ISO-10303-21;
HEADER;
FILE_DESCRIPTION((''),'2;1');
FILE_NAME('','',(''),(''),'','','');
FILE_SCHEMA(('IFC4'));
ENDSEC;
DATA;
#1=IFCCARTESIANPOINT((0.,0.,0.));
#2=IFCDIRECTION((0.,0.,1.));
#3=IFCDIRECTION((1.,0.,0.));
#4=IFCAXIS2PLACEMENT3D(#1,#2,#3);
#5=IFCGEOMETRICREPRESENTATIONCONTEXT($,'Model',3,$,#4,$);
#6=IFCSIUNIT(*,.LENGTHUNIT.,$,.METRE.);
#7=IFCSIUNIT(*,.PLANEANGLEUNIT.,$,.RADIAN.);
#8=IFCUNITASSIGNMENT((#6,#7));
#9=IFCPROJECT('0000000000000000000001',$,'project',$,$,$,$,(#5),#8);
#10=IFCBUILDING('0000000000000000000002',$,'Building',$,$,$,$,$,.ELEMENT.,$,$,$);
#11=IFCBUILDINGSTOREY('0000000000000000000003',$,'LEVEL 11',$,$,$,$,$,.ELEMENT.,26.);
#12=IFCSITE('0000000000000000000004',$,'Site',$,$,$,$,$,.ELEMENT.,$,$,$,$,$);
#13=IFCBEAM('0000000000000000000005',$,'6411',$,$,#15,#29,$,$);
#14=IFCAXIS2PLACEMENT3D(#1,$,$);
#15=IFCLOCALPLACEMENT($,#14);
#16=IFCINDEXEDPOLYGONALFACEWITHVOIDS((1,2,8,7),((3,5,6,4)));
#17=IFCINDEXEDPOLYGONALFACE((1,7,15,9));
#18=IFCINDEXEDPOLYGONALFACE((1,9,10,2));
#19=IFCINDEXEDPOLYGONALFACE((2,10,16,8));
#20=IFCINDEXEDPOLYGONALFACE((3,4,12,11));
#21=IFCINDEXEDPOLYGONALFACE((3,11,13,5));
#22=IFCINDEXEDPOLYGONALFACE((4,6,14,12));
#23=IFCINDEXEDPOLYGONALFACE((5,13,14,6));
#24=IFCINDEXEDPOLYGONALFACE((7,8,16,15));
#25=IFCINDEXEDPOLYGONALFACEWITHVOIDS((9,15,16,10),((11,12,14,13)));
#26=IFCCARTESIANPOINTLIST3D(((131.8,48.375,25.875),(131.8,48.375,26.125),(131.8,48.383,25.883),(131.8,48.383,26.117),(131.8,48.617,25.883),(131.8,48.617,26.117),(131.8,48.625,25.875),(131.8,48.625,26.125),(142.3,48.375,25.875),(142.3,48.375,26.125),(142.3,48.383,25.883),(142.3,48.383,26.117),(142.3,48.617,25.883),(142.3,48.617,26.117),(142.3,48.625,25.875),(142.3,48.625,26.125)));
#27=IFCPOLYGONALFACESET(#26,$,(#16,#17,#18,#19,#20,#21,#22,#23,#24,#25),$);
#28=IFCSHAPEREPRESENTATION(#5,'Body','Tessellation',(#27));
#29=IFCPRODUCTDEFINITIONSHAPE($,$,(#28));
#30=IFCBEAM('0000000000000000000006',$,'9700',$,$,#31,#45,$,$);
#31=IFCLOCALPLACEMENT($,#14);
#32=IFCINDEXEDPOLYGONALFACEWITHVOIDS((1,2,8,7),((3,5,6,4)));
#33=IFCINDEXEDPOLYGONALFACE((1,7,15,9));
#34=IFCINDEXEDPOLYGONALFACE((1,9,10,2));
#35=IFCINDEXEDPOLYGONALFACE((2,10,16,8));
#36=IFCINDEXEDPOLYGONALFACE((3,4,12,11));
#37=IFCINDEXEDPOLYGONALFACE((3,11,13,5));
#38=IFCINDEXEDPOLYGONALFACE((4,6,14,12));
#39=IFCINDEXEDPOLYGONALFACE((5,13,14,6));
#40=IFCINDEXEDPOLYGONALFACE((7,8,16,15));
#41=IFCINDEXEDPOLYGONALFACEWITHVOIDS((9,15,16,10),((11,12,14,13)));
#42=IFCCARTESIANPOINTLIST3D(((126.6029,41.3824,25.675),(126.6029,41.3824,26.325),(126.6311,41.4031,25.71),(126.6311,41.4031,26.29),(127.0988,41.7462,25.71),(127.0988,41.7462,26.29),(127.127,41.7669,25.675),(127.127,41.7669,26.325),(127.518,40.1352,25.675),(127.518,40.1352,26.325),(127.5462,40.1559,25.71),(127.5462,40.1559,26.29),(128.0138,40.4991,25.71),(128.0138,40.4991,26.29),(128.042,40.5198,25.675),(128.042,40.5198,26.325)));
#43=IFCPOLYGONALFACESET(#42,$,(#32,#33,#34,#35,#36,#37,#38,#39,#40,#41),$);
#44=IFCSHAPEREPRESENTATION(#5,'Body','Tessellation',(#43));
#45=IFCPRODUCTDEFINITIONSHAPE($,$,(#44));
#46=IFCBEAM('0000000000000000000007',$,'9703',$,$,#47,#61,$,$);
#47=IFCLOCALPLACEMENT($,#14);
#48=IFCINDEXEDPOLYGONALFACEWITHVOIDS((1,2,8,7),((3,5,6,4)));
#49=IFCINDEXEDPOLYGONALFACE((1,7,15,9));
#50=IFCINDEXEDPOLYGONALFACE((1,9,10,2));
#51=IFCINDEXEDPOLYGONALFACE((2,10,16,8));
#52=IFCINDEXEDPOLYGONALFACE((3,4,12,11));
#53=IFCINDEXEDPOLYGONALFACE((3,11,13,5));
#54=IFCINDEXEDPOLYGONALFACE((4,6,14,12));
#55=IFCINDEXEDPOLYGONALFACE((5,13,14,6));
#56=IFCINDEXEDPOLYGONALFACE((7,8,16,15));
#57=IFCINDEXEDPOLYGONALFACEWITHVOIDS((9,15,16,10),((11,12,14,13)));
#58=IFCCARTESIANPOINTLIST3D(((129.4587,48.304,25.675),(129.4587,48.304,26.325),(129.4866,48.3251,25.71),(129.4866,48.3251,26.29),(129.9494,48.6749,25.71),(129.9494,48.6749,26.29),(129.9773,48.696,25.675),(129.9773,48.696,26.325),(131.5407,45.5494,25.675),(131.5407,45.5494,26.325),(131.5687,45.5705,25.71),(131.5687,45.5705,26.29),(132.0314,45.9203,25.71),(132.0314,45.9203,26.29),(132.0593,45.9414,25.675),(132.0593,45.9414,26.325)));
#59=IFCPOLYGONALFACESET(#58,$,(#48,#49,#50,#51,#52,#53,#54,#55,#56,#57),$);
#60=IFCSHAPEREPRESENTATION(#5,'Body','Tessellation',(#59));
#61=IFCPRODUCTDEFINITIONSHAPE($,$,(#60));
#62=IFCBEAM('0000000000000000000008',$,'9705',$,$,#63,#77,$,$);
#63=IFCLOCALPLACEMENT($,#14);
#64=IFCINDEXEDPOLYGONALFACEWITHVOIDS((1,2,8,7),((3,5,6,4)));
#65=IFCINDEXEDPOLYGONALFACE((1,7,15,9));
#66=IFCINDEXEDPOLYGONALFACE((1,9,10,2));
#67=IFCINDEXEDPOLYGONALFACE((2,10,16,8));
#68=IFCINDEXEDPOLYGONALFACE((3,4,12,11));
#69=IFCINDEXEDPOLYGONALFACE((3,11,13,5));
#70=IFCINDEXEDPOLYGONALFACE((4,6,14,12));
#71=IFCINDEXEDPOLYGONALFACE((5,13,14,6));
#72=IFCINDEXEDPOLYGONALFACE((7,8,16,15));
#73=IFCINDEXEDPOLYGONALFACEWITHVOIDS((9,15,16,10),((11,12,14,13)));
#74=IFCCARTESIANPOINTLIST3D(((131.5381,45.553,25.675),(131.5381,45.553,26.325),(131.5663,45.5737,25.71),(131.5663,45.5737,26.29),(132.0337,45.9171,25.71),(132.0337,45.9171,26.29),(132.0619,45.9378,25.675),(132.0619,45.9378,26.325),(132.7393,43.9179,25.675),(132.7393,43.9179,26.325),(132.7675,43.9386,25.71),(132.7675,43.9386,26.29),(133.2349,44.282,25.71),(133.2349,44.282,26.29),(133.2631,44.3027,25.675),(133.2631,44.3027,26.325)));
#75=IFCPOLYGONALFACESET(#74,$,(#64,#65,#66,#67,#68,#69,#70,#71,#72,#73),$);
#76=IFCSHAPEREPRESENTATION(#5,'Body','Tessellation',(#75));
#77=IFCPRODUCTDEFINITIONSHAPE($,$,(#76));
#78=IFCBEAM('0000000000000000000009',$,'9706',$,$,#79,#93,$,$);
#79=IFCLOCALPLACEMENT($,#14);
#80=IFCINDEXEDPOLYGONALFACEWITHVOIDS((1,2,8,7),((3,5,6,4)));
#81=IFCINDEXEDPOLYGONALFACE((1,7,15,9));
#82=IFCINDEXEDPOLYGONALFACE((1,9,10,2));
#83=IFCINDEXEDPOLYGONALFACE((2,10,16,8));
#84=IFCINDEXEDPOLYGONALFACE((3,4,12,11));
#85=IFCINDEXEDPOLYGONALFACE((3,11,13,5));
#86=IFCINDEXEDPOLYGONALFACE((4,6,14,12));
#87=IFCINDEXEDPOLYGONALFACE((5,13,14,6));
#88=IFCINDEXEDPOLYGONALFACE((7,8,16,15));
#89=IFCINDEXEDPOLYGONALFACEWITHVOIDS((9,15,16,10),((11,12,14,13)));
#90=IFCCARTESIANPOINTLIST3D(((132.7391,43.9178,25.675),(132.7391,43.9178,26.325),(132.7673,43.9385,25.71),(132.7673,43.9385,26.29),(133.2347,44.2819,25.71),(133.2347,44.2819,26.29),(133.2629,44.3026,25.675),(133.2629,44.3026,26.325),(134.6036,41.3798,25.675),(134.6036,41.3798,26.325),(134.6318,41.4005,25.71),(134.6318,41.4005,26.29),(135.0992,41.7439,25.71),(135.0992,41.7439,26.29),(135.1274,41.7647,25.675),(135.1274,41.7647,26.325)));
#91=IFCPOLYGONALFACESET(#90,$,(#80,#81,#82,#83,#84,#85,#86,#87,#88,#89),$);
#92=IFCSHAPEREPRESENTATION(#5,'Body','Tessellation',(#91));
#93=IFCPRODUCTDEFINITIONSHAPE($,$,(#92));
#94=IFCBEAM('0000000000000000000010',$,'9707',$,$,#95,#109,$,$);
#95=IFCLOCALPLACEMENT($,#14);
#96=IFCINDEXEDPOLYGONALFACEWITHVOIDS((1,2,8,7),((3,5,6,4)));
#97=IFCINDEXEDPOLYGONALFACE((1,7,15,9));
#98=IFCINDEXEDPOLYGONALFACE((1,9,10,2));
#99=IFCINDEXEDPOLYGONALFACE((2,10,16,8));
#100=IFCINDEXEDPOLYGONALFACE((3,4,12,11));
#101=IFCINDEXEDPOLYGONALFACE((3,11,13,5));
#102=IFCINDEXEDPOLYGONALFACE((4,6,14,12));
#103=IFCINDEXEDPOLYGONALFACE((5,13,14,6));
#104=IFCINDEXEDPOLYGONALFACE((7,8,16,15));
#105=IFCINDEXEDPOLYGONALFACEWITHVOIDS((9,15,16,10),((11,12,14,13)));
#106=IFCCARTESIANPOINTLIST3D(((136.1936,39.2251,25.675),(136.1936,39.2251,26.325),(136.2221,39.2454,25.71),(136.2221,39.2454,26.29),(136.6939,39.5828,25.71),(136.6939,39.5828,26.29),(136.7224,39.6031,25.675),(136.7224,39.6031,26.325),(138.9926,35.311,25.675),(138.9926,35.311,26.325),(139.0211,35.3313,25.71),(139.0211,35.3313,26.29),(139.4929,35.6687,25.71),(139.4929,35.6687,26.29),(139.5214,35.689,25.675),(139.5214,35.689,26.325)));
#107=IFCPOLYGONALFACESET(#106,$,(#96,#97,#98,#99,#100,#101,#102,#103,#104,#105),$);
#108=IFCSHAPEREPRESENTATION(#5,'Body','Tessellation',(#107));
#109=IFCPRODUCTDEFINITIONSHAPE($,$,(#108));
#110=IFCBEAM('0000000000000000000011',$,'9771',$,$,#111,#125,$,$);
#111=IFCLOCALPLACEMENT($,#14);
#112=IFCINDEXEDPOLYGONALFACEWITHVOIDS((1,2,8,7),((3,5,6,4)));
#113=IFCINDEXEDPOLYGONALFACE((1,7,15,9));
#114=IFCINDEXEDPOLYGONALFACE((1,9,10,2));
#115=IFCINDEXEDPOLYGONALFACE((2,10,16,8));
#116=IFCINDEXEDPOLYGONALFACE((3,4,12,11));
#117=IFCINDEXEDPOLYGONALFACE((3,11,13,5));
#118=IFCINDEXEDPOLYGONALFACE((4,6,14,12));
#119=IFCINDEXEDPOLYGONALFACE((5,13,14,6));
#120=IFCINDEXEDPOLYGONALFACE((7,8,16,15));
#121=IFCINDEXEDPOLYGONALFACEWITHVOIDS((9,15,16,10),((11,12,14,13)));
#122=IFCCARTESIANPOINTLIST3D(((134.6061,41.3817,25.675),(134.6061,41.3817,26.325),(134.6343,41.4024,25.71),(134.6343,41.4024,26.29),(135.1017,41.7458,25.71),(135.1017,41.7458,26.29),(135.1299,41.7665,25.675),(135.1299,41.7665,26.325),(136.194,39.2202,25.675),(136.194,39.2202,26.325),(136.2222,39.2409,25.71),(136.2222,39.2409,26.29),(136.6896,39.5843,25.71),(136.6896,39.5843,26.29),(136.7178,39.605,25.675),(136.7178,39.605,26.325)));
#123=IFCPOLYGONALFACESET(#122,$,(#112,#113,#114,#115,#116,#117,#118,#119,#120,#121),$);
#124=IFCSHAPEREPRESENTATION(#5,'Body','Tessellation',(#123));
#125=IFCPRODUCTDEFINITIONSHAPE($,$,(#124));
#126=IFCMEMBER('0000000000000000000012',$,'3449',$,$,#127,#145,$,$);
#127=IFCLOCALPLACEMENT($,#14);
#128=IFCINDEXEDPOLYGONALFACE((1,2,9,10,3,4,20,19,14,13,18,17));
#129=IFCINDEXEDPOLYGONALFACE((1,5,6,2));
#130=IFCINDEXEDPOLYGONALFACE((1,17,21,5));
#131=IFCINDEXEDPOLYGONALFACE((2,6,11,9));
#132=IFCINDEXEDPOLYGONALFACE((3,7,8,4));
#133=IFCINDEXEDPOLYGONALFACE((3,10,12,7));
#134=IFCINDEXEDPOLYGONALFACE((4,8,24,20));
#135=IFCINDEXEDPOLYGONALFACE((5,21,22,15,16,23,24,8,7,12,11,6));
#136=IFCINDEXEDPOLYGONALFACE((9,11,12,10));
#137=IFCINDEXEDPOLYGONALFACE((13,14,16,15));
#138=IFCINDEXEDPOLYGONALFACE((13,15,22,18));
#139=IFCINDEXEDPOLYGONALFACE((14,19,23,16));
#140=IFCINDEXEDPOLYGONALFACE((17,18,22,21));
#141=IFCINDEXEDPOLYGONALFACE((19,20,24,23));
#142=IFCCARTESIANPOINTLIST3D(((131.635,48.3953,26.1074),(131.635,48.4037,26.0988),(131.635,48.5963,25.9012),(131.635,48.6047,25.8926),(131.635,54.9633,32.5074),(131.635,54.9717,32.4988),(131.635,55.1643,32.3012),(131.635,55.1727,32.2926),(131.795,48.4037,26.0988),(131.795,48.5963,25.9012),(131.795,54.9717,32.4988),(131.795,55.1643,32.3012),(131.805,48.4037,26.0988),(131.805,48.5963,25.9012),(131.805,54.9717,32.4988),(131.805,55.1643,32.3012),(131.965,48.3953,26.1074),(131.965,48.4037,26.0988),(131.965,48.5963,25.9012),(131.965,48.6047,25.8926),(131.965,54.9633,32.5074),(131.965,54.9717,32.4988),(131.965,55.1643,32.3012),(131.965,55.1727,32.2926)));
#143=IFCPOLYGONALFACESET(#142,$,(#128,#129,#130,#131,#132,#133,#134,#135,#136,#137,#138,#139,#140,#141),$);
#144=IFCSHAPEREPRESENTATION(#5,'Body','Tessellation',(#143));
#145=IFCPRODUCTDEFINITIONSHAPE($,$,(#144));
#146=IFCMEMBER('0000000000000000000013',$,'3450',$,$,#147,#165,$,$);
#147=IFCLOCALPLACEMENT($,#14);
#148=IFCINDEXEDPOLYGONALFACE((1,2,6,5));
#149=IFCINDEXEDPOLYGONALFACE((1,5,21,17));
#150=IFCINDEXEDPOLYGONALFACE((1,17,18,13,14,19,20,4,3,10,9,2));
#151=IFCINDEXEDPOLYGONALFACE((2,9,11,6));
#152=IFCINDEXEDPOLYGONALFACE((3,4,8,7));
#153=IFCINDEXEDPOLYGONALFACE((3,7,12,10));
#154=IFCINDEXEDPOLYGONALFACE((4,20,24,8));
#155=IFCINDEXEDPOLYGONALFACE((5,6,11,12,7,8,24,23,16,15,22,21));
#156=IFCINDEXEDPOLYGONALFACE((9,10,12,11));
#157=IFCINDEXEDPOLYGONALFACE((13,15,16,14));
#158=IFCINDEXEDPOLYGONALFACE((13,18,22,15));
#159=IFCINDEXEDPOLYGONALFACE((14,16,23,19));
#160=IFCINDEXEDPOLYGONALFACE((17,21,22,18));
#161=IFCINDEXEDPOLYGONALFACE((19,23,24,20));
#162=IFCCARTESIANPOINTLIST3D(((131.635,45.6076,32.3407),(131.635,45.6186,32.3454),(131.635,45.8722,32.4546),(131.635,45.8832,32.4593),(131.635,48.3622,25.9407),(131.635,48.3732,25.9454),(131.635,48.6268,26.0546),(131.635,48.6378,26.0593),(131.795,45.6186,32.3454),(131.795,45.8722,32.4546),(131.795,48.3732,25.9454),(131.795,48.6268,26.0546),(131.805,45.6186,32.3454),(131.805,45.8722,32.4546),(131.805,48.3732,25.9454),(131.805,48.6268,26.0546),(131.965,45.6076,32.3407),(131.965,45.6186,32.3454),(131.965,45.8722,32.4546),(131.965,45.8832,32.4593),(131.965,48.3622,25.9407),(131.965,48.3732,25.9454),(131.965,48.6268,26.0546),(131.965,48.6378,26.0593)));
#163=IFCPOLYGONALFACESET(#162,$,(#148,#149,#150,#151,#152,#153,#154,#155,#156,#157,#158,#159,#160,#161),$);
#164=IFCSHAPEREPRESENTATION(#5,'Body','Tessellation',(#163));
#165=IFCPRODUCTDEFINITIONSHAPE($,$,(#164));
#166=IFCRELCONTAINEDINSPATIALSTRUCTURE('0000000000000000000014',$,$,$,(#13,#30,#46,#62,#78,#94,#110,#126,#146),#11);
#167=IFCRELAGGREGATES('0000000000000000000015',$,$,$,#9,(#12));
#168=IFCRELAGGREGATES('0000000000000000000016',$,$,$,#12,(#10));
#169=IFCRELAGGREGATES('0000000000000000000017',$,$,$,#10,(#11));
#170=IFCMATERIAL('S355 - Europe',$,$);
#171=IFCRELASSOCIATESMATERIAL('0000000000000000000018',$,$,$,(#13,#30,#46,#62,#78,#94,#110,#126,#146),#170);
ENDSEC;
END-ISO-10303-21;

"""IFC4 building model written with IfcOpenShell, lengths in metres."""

from ifc_helpers import new_model, si_unit, frame, origin_with_axes, origin_2d_with_axis, place, context, project, spatial, hollow_rectangle, i_section, extrude, material, material_profile, profile_set, profile_usage, element, save


model = new_model("IFC4")

# Units and contexts
model_context = context("Model", 3, world=origin_with_axes())
ifc_project = project(units=[si_unit("LENGTHUNIT", "METRE"), si_unit("PLANEANGLEUNIT", "RADIAN")], contexts=[model_context])

# Site, building, storey
site = spatial("IfcSite", under=ifc_project, Name="Site", CompositionType="ELEMENT")
building = spatial("IfcBuilding", under=site, Name="Building", CompositionType="ELEMENT")
storey = spatial("IfcBuildingStorey", under=building, Name="LEVEL 11", CompositionType="ELEMENT", Elevation=26.0)

# Shared definitions
ifc_material = material(Name="S355 - Europe")

# Beams
ifc_material_profile_1 = material_profile(ifc_material, hollow_rectangle(XDim=0.25, YDim=0.25, WallThickness=0.008, at=origin_2d_with_axis()))
ifc_profile_set_1 = profile_set([ifc_material_profile_1])
ifc_profile_usage_1 = profile_usage(ifc_profile_set_1, cardinal=10)
beam_1_placement = place(None, frame((131.8, 48.5, 26.0), z_axis=(1.0, 0.0, 0.0), x_axis=(0.0, 1.0, 0.0)))
element("IfcBeam", 1, at=beam_1_placement, inside=storey, material=ifc_profile_usage_1, Name="6411", context=model_context, shape_type="SweptSolid", body=[
    extrude(hollow_rectangle(XDim=0.25, YDim=0.25, WallThickness=0.008, at=origin_2d_with_axis()), origin_with_axes(), (0.0, 0.0, 1.0), 10.5),
])
ifc_material_profile_2 = material_profile(ifc_material, hollow_rectangle(XDim=0.65, YDim=0.65, WallThickness=0.035, at=origin_2d_with_axis()))
ifc_profile_set_2 = profile_set([ifc_material_profile_2])
ifc_profile_usage_2 = profile_usage(ifc_profile_set_2, cardinal=10)
beam_2_placement = place(None, frame((127.78, 40.3275, 26.0), z_axis=(-0.591557, 0.806263, 0.0), x_axis=(-0.805765, -0.592235, 0.0)))
element("IfcBeam", 2, at=beam_2_placement, inside=storey, material=ifc_profile_usage_2, Name="9700", context=model_context, shape_type="SweptSolid", body=[
    extrude(hollow_rectangle(XDim=0.65, YDim=0.65, WallThickness=0.035, at=origin_2d_with_axis()), origin_with_axes(), (0.0, 0.0, 1.0), 1.5469),
])
ifc_material_profile_3 = material_profile(ifc_material, hollow_rectangle(XDim=0.65, YDim=0.65, WallThickness=0.035, at=origin_2d_with_axis()))
ifc_profile_set_3 = profile_set([ifc_material_profile_3])
ifc_profile_usage_3 = profile_usage(ifc_profile_set_3, cardinal=10)
beam_3_placement = place(None, frame((129.718, 48.5, 26.0), z_axis=(0.602972, -0.797762, 0.0), x_axis=(0.797763, 0.602971, 0.0)))
element("IfcBeam", 3, at=beam_3_placement, inside=storey, material=ifc_profile_usage_3, Name="9703", context=model_context, shape_type="SweptSolid", body=[
    extrude(hollow_rectangle(XDim=0.65, YDim=0.65, WallThickness=0.035, at=origin_2d_with_axis()), origin_with_axes(), (0.0, 0.0, 1.0), 3.4529),
])
ifc_material_profile_4 = material_profile(ifc_material, hollow_rectangle(XDim=0.65, YDim=0.65, WallThickness=0.035, at=origin_2d_with_axis()))
ifc_profile_set_4 = profile_set([ifc_material_profile_4])
ifc_profile_usage_4 = profile_usage(ifc_profile_set_4, cardinal=10)
beam_4_placement = place(None, frame((131.8, 45.7454, 26.0), z_axis=(0.592045, -0.805905, 0.0), x_axis=(0.805798, 0.59219, 0.0)))
element("IfcBeam", 4, at=beam_4_placement, inside=storey, material=ifc_profile_usage_4, Name="9705", context=model_context, shape_type="SweptSolid", body=[
    extrude(hollow_rectangle(XDim=0.65, YDim=0.65, WallThickness=0.035, at=origin_2d_with_axis()), origin_with_axes(), (0.0, 0.0, 1.0), 2.0289),
])
ifc_material_profile_5 = material_profile(ifc_material, hollow_rectangle(XDim=0.65, YDim=0.65, WallThickness=0.035, at=origin_2d_with_axis()))
ifc_profile_set_5 = profile_set([ifc_material_profile_5])
ifc_profile_usage_5 = profile_usage(ifc_profile_set_5, cardinal=10)
beam_5_placement = place(None, frame((133.001, 44.1102, 26.0), z_axis=(0.592045, -0.805905, 0.0), x_axis=(0.805056, 0.593199, 0.0)))
element("IfcBeam", 5, at=beam_5_placement, inside=storey, material=ifc_profile_usage_5, Name="9706", context=model_context, shape_type="SweptSolid", body=[
    extrude(hollow_rectangle(XDim=0.65, YDim=0.65, WallThickness=0.035, at=origin_2d_with_axis()), origin_with_axes(), (0.0, 0.0, 1.0), 3.1492),
])
ifc_material_profile_6 = material_profile(ifc_material, hollow_rectangle(XDim=0.65, YDim=0.65, WallThickness=0.035, at=origin_2d_with_axis()))
ifc_profile_set_6 = profile_set([ifc_material_profile_6])
ifc_profile_usage_6 = profile_usage(ifc_profile_set_6, cardinal=10)
beam_6_placement = place(None, frame((136.458, 39.4141, 26.0), z_axis=(0.58168, -0.813417, 0.0), x_axis=(0.813417, 0.58168, 0.0)))
element("IfcBeam", 6, at=beam_6_placement, inside=storey, material=ifc_profile_usage_6, Name="9707", context=model_context, shape_type="SweptSolid", body=[
    extrude(hollow_rectangle(XDim=0.65, YDim=0.65, WallThickness=0.035, at=origin_2d_with_axis()), origin_with_axes(), (0.0, 0.0, 1.0), 4.8119),
])
ifc_material_profile_7 = material_profile(ifc_material, hollow_rectangle(XDim=0.65, YDim=0.65, WallThickness=0.035, at=origin_2d_with_axis()))
ifc_profile_set_7 = profile_set([ifc_material_profile_7])
ifc_profile_usage_7 = profile_usage(ifc_profile_set_7, cardinal=10)
beam_7_placement = place(None, frame((134.868, 41.5741, 26.0), z_axis=(0.592045, -0.805905, 0.0), x_axis=(0.805056, 0.593199, 0.0)))
element("IfcBeam", 7, at=beam_7_placement, inside=storey, material=ifc_profile_usage_7, Name="9771", context=model_context, shape_type="SweptSolid", body=[
    extrude(hollow_rectangle(XDim=0.65, YDim=0.65, WallThickness=0.035, at=origin_2d_with_axis()), origin_with_axes(), (0.0, 0.0, 1.0), 2.6821),
])

# Members
ifc_material_profile_8 = material_profile(ifc_material, i_section(OverallWidth=0.33, OverallDepth=0.3, WebThickness=0.01, FlangeThickness=0.012, at=origin_2d_with_axis()))
ifc_profile_set_8 = profile_set([ifc_material_profile_8])
ifc_profile_usage_8 = profile_usage(ifc_profile_set_8, cardinal=10)
member_1_placement = place(None, frame((131.8, 55.068, 32.4), z_axis=(0.0, -0.716207, -0.697888), x_axis=(1.0, 0.0, 0.0)))
element("IfcMember", 8, at=member_1_placement, inside=storey, material=ifc_profile_usage_8, Name="3449", context=model_context, shape_type="SweptSolid", body=[
    extrude(i_section(OverallWidth=0.33, OverallDepth=0.3, WebThickness=0.01, FlangeThickness=0.012, at=origin_2d_with_axis()), origin_with_axes(), (0.0, 0.0, 1.0), 9.1705),
])
ifc_material_profile_9 = material_profile(ifc_material, i_section(OverallWidth=0.33, OverallDepth=0.3, WebThickness=0.01, FlangeThickness=0.012, at=origin_2d_with_axis()))
ifc_profile_set_9 = profile_set([ifc_material_profile_9])
ifc_profile_usage_9 = profile_usage(ifc_profile_set_9, cardinal=10)
member_2_placement = place(None, frame((131.8, 48.5, 26.0), z_axis=(0.0, -0.395343, 0.918534), x_axis=(1.0, 0.0, 0.0)))
element("IfcMember", 9, at=member_2_placement, inside=storey, material=ifc_profile_usage_9, Name="3450", context=model_context, shape_type="SweptSolid", body=[
    extrude(i_section(OverallWidth=0.33, OverallDepth=0.3, WebThickness=0.01, FlangeThickness=0.012, at=origin_2d_with_axis()), origin_with_axes(), (0.0, 0.0, 1.0), 6.9676),
])

save(model, "model.ifc")
